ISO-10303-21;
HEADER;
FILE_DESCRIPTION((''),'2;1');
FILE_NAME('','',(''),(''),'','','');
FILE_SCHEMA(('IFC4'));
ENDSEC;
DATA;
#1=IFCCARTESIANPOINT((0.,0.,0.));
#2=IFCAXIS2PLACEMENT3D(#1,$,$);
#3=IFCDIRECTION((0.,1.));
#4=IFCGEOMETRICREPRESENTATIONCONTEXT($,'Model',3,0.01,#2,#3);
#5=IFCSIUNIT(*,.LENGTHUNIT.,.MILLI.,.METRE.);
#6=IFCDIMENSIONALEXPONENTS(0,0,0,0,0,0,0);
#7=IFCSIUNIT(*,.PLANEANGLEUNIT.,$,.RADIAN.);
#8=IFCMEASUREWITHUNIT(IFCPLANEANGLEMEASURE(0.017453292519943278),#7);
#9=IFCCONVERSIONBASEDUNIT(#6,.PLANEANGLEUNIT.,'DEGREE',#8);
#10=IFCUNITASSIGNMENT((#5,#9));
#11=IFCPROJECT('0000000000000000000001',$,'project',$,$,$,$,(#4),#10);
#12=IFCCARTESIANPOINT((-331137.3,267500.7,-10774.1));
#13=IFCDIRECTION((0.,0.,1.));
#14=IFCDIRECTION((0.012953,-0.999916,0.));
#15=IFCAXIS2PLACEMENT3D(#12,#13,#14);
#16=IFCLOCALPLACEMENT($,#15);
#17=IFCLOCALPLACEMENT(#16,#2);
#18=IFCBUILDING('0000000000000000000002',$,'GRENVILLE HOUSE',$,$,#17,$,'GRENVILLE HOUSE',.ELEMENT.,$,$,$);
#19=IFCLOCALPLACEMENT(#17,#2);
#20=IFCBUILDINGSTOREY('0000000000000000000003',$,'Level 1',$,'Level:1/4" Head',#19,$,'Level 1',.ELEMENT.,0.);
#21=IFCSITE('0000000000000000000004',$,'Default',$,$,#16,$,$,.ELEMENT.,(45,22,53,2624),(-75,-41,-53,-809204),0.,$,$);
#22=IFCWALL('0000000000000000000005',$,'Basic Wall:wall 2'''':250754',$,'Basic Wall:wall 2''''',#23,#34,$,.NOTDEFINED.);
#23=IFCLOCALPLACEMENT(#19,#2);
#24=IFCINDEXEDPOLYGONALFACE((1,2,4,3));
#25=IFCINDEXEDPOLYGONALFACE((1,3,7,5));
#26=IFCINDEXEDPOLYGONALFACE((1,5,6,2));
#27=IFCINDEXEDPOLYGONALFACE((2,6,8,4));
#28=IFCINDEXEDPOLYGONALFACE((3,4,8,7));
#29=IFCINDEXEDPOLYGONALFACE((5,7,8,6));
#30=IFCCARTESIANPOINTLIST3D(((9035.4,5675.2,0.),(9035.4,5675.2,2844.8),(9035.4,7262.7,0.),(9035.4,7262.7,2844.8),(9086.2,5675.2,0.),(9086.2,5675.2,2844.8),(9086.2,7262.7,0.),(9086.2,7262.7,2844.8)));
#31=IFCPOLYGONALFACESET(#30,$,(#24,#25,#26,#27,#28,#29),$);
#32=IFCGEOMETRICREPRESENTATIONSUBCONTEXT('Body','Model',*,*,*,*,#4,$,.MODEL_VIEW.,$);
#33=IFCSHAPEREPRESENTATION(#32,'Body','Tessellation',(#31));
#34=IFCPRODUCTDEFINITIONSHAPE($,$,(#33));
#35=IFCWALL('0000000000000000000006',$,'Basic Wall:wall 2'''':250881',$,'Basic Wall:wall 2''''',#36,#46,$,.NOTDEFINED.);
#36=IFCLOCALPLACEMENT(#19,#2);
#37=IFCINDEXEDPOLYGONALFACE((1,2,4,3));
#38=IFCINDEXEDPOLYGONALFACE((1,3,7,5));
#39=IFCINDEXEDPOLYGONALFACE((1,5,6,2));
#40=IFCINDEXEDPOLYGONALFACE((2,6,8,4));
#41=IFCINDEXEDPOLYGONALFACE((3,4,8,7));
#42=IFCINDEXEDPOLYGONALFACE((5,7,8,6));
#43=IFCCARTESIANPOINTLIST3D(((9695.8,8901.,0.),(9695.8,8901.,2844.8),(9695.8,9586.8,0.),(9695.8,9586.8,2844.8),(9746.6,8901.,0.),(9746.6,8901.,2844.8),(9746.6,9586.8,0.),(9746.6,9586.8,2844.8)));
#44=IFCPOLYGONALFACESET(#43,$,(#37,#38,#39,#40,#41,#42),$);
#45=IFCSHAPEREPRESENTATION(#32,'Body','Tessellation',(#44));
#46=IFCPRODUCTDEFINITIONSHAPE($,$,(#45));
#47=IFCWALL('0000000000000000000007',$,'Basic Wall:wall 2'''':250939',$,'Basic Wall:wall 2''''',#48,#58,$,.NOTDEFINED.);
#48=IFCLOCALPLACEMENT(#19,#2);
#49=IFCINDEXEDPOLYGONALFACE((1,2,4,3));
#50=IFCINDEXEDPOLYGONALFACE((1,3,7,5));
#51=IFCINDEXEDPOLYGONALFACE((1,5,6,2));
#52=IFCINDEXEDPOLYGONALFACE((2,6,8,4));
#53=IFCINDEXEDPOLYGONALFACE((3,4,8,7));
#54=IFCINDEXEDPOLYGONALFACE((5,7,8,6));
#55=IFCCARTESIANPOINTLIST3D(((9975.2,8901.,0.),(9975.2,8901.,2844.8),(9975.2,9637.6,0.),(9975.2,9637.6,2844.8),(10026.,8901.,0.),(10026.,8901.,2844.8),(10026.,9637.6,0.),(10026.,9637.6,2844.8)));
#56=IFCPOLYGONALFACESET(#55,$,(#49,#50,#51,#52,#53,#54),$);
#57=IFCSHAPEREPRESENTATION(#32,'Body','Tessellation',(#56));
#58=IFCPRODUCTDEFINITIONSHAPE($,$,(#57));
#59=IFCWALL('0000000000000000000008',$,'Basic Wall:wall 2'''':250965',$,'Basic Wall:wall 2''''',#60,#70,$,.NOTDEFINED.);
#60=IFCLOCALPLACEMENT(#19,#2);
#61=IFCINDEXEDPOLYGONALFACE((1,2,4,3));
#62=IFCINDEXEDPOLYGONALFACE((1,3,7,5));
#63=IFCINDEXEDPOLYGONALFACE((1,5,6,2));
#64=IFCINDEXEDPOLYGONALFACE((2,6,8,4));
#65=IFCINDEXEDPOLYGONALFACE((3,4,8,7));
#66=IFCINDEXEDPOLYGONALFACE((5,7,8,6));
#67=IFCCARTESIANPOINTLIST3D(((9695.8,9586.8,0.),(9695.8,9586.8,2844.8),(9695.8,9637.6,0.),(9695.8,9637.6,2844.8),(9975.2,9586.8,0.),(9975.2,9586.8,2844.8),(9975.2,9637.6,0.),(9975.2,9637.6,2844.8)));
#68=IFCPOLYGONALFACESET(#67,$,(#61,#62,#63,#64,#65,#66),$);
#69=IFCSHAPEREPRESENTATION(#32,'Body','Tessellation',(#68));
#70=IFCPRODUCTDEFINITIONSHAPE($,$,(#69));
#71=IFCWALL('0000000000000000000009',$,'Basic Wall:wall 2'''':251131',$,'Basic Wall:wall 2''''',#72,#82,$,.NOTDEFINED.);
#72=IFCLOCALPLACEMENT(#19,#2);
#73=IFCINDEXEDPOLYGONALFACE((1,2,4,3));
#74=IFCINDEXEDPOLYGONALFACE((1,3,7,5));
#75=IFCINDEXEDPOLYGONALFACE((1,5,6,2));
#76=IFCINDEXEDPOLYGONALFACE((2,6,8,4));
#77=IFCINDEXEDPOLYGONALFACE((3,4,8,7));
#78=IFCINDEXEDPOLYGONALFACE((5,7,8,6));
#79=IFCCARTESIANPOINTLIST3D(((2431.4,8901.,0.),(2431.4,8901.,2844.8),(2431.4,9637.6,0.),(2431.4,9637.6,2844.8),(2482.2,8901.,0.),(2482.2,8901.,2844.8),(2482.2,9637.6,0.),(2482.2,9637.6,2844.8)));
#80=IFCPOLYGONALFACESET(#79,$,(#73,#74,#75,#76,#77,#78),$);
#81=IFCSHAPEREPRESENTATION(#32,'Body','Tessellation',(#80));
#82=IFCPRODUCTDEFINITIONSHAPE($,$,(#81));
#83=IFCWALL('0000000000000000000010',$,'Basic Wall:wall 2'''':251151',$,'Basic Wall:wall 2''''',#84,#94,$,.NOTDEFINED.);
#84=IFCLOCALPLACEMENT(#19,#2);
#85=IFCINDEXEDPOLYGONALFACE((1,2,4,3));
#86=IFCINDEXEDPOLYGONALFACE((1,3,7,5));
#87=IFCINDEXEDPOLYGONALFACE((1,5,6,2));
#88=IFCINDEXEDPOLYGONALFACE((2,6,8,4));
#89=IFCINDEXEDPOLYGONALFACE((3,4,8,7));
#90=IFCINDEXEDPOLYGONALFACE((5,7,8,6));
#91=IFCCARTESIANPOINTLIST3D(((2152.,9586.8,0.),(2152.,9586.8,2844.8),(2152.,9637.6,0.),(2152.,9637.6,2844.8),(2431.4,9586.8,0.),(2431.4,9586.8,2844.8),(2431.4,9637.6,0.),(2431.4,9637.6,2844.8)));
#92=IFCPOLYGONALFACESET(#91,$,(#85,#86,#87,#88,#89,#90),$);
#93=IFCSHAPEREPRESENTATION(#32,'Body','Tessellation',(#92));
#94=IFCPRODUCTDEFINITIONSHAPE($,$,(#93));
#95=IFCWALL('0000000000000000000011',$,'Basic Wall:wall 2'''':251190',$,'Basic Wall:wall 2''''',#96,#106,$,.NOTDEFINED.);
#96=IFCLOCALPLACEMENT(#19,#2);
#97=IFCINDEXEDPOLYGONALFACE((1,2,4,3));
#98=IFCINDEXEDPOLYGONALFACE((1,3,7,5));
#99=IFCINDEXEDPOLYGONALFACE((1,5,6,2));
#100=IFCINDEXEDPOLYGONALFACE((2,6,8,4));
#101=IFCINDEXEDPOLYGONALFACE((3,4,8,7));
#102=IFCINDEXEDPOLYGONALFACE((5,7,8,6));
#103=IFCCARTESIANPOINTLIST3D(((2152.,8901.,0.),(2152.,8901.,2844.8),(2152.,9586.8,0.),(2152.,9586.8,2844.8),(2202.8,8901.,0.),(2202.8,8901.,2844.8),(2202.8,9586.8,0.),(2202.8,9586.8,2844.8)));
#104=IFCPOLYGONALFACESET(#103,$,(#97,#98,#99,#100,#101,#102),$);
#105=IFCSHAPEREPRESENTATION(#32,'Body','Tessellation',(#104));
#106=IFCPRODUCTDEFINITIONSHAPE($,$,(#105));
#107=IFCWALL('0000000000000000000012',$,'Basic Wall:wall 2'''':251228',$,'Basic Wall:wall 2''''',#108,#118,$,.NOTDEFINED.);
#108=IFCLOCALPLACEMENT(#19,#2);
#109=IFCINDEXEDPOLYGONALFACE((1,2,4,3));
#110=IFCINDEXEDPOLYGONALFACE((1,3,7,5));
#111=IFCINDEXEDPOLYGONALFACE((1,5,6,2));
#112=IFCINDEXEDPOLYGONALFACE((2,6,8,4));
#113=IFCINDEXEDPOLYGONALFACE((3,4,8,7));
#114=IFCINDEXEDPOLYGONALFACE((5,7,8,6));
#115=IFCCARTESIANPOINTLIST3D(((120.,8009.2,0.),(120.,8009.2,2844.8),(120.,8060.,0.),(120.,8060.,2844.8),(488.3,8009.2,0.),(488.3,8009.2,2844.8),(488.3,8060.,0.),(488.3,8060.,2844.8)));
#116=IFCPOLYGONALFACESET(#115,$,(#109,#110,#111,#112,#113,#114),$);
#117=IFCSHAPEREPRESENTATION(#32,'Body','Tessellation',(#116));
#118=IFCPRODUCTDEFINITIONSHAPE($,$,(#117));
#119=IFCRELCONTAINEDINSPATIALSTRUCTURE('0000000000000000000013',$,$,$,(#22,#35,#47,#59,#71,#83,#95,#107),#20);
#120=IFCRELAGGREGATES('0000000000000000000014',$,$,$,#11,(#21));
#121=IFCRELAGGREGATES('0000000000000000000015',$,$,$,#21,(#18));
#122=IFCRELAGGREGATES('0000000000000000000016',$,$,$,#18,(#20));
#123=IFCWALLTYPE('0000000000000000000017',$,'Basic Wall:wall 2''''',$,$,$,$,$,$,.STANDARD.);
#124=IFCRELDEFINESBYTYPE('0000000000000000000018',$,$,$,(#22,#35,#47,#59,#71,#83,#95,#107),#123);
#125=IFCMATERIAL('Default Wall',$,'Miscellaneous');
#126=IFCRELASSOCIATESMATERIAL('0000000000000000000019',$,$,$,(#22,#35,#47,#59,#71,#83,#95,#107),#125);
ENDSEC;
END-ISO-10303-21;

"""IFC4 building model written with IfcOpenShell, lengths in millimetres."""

from ifc_helpers import new_model, entity, si_unit, converted_unit, direction, frame, origin, place, context, subcontext, project, spatial, indexed_curve, outline, extrude, material, type_object, element, save


model = new_model("IFC4")

# Units and contexts
model_context = context("Model", 3, precision=0.01, world=origin(), true_north=direction((0.0, 1.0)))
body_context = subcontext(model_context, "Body", "Model", "MODEL_VIEW")
ifc_project = project(units=[si_unit("LENGTHUNIT", "METRE", prefix="MILLI"), converted_unit("PLANEANGLEUNIT", "DEGREE", entity("IfcPlaneAngleMeasure", 0.017453292519943278), si_unit("PLANEANGLEUNIT", "RADIAN"), dimensions=[0, 0, 0, 0, 0, 0, 0])], contexts=[model_context])

# Site, building, storey
site_placement = place(None, frame((-331137.3, 267500.7, -10774.1), z_axis=(0.0, 0.0, 1.0), x_axis=(0.012953, -0.999916, 0.0)))
site = spatial("IfcSite", under=ifc_project, at=site_placement, Name="Default", CompositionType="ELEMENT", RefLatitude=(45, 22, 53, 2624), RefLongitude=(-75, -41, -53, -809204), RefElevation=0.0)
building_placement = place(site_placement, origin())
building = spatial("IfcBuilding", under=site, at=building_placement, Name="GRENVILLE HOUSE", LongName="GRENVILLE HOUSE", CompositionType="ELEMENT")
storey_placement = place(building_placement, origin())
storey = spatial("IfcBuildingStorey", under=building, at=storey_placement, Name="Level 1", ObjectType="Level:1/4\" Head", LongName="Level 1", CompositionType="ELEMENT", Elevation=0.0)

# Walls
ifc_material = material(Name="Default Wall", Category="Miscellaneous")
wall_type_1 = type_object("IfcWallType", Name="Basic Wall:wall 2''", PredefinedType="STANDARD")
wall_1_placement = place(storey_placement, frame((9060.8, 7262.7, 0.0), z_axis=(0.0, 0.0, 1.0), x_axis=(0.0, -1.0, 0.0)))
element("IfcWall", 1, at=wall_1_placement, inside=storey, type_object=wall_type_1, material=ifc_material, Name="Basic Wall:wall 2'':250754", ObjectType="Basic Wall:wall 2''", PredefinedType="NOTDEFINED", context=body_context, shape_type="SweptSolid", body=[
    extrude(outline(indexed_curve([(1587.5, 25.4), (0.0, 25.4), (0.0, -25.4), (1587.5, -25.4), (1587.5, 25.4)], self_intersect=False)), origin(), (0.0, 0.0, 1.0), 2844.8),
])
wall_2_placement = place(storey_placement, frame((9721.2, 8901.0, 0.0), z_axis=(0.0, 0.0, 1.0), x_axis=(0.0, 1.0, 0.0)))
element("IfcWall", 2, at=wall_2_placement, inside=storey, type_object=wall_type_1, material=ifc_material, Name="Basic Wall:wall 2'':250881", ObjectType="Basic Wall:wall 2''", PredefinedType="NOTDEFINED", context=body_context, shape_type="SweptSolid", body=[
    extrude(outline(indexed_curve([(685.8, 25.4), (0.0, 25.4), (0.0, -25.4), (685.8, -25.4), (685.8, 25.4)], self_intersect=False)), origin(), (0.0, 0.0, 1.0), 2844.8),
])
wall_3_placement = place(storey_placement, frame((10000.6, 8901.0, 0.0), z_axis=(0.0, 0.0, 1.0), x_axis=(0.0, 1.0, 0.0)))
element("IfcWall", 3, at=wall_3_placement, inside=storey, type_object=wall_type_1, material=ifc_material, Name="Basic Wall:wall 2'':250939", ObjectType="Basic Wall:wall 2''", PredefinedType="NOTDEFINED", context=body_context, shape_type="SweptSolid", body=[
    extrude(outline(indexed_curve([(736.6, 25.4), (0.0, 25.4), (0.0, -25.4), (736.6, -25.4), (736.6, 25.4)], self_intersect=False)), origin(), (0.0, 0.0, 1.0), 2844.8),
])
wall_4_placement = place(storey_placement, frame((9975.2, 9612.2, 0.0), z_axis=(0.0, 0.0, 1.0), x_axis=(-1.0, 0.0, 0.0)))
element("IfcWall", 4, at=wall_4_placement, inside=storey, type_object=wall_type_1, material=ifc_material, Name="Basic Wall:wall 2'':250965", ObjectType="Basic Wall:wall 2''", PredefinedType="NOTDEFINED", context=body_context, shape_type="SweptSolid", body=[
    extrude(outline(indexed_curve([(279.4, 25.4), (0.0, 25.4), (0.0, -25.4), (279.4, -25.4), (279.4, 25.4)], self_intersect=False)), origin(), (0.0, 0.0, 1.0), 2844.8),
])
wall_5_placement = place(storey_placement, frame((2456.8, 8901.0, 0.0), z_axis=(0.0, 0.0, 1.0), x_axis=(0.0, 1.0, 0.0)))
element("IfcWall", 5, at=wall_5_placement, inside=storey, type_object=wall_type_1, material=ifc_material, Name="Basic Wall:wall 2'':251131", ObjectType="Basic Wall:wall 2''", PredefinedType="NOTDEFINED", context=body_context, shape_type="SweptSolid", body=[
    extrude(outline(indexed_curve([(736.6, 25.4), (0.0, 25.4), (0.0, -25.4), (736.6, -25.4), (736.6, 25.4)], self_intersect=False)), origin(), (0.0, 0.0, 1.0), 2844.8),
])
wall_6_placement = place(storey_placement, frame((2431.4, 9612.2, 0.0), z_axis=(0.0, 0.0, 1.0), x_axis=(-1.0, 0.0, 0.0)))
element("IfcWall", 6, at=wall_6_placement, inside=storey, type_object=wall_type_1, material=ifc_material, Name="Basic Wall:wall 2'':251151", ObjectType="Basic Wall:wall 2''", PredefinedType="NOTDEFINED", context=body_context, shape_type="SweptSolid", body=[
    extrude(outline(indexed_curve([(279.4, 25.4), (0.0, 25.4), (0.0, -25.4), (279.4, -25.4), (279.4, 25.4)], self_intersect=False)), origin(), (0.0, 0.0, 1.0), 2844.8),
])
wall_7_placement = place(storey_placement, frame((2177.4, 9586.8, 0.0), z_axis=(0.0, 0.0, 1.0), x_axis=(0.0, -1.0, 0.0)))
element("IfcWall", 7, at=wall_7_placement, inside=storey, type_object=wall_type_1, material=ifc_material, Name="Basic Wall:wall 2'':251190", ObjectType="Basic Wall:wall 2''", PredefinedType="NOTDEFINED", context=body_context, shape_type="SweptSolid", body=[
    extrude(outline(indexed_curve([(685.8, 25.4), (0.0, 25.4), (0.0, -25.4), (685.8, -25.4), (685.8, 25.4)], self_intersect=False)), origin(), (0.0, 0.0, 1.0), 2844.8),
])
wall_8_placement = place(storey_placement, frame((488.3, 8034.6, 0.0), z_axis=(0.0, 0.0, 1.0), x_axis=(-1.0, 0.0, 0.0)))
element("IfcWall", 8, at=wall_8_placement, inside=storey, type_object=wall_type_1, material=ifc_material, Name="Basic Wall:wall 2'':251228", ObjectType="Basic Wall:wall 2''", PredefinedType="NOTDEFINED", context=body_context, shape_type="SweptSolid", body=[
    extrude(outline(indexed_curve([(368.3, 25.4), (0.0, 25.4), (0.0, -25.4), (368.3, -25.4), (368.3, 25.4)], self_intersect=False)), origin(), (0.0, 0.0, 1.0), 2844.8),
])

save(model, "model.ifc")
